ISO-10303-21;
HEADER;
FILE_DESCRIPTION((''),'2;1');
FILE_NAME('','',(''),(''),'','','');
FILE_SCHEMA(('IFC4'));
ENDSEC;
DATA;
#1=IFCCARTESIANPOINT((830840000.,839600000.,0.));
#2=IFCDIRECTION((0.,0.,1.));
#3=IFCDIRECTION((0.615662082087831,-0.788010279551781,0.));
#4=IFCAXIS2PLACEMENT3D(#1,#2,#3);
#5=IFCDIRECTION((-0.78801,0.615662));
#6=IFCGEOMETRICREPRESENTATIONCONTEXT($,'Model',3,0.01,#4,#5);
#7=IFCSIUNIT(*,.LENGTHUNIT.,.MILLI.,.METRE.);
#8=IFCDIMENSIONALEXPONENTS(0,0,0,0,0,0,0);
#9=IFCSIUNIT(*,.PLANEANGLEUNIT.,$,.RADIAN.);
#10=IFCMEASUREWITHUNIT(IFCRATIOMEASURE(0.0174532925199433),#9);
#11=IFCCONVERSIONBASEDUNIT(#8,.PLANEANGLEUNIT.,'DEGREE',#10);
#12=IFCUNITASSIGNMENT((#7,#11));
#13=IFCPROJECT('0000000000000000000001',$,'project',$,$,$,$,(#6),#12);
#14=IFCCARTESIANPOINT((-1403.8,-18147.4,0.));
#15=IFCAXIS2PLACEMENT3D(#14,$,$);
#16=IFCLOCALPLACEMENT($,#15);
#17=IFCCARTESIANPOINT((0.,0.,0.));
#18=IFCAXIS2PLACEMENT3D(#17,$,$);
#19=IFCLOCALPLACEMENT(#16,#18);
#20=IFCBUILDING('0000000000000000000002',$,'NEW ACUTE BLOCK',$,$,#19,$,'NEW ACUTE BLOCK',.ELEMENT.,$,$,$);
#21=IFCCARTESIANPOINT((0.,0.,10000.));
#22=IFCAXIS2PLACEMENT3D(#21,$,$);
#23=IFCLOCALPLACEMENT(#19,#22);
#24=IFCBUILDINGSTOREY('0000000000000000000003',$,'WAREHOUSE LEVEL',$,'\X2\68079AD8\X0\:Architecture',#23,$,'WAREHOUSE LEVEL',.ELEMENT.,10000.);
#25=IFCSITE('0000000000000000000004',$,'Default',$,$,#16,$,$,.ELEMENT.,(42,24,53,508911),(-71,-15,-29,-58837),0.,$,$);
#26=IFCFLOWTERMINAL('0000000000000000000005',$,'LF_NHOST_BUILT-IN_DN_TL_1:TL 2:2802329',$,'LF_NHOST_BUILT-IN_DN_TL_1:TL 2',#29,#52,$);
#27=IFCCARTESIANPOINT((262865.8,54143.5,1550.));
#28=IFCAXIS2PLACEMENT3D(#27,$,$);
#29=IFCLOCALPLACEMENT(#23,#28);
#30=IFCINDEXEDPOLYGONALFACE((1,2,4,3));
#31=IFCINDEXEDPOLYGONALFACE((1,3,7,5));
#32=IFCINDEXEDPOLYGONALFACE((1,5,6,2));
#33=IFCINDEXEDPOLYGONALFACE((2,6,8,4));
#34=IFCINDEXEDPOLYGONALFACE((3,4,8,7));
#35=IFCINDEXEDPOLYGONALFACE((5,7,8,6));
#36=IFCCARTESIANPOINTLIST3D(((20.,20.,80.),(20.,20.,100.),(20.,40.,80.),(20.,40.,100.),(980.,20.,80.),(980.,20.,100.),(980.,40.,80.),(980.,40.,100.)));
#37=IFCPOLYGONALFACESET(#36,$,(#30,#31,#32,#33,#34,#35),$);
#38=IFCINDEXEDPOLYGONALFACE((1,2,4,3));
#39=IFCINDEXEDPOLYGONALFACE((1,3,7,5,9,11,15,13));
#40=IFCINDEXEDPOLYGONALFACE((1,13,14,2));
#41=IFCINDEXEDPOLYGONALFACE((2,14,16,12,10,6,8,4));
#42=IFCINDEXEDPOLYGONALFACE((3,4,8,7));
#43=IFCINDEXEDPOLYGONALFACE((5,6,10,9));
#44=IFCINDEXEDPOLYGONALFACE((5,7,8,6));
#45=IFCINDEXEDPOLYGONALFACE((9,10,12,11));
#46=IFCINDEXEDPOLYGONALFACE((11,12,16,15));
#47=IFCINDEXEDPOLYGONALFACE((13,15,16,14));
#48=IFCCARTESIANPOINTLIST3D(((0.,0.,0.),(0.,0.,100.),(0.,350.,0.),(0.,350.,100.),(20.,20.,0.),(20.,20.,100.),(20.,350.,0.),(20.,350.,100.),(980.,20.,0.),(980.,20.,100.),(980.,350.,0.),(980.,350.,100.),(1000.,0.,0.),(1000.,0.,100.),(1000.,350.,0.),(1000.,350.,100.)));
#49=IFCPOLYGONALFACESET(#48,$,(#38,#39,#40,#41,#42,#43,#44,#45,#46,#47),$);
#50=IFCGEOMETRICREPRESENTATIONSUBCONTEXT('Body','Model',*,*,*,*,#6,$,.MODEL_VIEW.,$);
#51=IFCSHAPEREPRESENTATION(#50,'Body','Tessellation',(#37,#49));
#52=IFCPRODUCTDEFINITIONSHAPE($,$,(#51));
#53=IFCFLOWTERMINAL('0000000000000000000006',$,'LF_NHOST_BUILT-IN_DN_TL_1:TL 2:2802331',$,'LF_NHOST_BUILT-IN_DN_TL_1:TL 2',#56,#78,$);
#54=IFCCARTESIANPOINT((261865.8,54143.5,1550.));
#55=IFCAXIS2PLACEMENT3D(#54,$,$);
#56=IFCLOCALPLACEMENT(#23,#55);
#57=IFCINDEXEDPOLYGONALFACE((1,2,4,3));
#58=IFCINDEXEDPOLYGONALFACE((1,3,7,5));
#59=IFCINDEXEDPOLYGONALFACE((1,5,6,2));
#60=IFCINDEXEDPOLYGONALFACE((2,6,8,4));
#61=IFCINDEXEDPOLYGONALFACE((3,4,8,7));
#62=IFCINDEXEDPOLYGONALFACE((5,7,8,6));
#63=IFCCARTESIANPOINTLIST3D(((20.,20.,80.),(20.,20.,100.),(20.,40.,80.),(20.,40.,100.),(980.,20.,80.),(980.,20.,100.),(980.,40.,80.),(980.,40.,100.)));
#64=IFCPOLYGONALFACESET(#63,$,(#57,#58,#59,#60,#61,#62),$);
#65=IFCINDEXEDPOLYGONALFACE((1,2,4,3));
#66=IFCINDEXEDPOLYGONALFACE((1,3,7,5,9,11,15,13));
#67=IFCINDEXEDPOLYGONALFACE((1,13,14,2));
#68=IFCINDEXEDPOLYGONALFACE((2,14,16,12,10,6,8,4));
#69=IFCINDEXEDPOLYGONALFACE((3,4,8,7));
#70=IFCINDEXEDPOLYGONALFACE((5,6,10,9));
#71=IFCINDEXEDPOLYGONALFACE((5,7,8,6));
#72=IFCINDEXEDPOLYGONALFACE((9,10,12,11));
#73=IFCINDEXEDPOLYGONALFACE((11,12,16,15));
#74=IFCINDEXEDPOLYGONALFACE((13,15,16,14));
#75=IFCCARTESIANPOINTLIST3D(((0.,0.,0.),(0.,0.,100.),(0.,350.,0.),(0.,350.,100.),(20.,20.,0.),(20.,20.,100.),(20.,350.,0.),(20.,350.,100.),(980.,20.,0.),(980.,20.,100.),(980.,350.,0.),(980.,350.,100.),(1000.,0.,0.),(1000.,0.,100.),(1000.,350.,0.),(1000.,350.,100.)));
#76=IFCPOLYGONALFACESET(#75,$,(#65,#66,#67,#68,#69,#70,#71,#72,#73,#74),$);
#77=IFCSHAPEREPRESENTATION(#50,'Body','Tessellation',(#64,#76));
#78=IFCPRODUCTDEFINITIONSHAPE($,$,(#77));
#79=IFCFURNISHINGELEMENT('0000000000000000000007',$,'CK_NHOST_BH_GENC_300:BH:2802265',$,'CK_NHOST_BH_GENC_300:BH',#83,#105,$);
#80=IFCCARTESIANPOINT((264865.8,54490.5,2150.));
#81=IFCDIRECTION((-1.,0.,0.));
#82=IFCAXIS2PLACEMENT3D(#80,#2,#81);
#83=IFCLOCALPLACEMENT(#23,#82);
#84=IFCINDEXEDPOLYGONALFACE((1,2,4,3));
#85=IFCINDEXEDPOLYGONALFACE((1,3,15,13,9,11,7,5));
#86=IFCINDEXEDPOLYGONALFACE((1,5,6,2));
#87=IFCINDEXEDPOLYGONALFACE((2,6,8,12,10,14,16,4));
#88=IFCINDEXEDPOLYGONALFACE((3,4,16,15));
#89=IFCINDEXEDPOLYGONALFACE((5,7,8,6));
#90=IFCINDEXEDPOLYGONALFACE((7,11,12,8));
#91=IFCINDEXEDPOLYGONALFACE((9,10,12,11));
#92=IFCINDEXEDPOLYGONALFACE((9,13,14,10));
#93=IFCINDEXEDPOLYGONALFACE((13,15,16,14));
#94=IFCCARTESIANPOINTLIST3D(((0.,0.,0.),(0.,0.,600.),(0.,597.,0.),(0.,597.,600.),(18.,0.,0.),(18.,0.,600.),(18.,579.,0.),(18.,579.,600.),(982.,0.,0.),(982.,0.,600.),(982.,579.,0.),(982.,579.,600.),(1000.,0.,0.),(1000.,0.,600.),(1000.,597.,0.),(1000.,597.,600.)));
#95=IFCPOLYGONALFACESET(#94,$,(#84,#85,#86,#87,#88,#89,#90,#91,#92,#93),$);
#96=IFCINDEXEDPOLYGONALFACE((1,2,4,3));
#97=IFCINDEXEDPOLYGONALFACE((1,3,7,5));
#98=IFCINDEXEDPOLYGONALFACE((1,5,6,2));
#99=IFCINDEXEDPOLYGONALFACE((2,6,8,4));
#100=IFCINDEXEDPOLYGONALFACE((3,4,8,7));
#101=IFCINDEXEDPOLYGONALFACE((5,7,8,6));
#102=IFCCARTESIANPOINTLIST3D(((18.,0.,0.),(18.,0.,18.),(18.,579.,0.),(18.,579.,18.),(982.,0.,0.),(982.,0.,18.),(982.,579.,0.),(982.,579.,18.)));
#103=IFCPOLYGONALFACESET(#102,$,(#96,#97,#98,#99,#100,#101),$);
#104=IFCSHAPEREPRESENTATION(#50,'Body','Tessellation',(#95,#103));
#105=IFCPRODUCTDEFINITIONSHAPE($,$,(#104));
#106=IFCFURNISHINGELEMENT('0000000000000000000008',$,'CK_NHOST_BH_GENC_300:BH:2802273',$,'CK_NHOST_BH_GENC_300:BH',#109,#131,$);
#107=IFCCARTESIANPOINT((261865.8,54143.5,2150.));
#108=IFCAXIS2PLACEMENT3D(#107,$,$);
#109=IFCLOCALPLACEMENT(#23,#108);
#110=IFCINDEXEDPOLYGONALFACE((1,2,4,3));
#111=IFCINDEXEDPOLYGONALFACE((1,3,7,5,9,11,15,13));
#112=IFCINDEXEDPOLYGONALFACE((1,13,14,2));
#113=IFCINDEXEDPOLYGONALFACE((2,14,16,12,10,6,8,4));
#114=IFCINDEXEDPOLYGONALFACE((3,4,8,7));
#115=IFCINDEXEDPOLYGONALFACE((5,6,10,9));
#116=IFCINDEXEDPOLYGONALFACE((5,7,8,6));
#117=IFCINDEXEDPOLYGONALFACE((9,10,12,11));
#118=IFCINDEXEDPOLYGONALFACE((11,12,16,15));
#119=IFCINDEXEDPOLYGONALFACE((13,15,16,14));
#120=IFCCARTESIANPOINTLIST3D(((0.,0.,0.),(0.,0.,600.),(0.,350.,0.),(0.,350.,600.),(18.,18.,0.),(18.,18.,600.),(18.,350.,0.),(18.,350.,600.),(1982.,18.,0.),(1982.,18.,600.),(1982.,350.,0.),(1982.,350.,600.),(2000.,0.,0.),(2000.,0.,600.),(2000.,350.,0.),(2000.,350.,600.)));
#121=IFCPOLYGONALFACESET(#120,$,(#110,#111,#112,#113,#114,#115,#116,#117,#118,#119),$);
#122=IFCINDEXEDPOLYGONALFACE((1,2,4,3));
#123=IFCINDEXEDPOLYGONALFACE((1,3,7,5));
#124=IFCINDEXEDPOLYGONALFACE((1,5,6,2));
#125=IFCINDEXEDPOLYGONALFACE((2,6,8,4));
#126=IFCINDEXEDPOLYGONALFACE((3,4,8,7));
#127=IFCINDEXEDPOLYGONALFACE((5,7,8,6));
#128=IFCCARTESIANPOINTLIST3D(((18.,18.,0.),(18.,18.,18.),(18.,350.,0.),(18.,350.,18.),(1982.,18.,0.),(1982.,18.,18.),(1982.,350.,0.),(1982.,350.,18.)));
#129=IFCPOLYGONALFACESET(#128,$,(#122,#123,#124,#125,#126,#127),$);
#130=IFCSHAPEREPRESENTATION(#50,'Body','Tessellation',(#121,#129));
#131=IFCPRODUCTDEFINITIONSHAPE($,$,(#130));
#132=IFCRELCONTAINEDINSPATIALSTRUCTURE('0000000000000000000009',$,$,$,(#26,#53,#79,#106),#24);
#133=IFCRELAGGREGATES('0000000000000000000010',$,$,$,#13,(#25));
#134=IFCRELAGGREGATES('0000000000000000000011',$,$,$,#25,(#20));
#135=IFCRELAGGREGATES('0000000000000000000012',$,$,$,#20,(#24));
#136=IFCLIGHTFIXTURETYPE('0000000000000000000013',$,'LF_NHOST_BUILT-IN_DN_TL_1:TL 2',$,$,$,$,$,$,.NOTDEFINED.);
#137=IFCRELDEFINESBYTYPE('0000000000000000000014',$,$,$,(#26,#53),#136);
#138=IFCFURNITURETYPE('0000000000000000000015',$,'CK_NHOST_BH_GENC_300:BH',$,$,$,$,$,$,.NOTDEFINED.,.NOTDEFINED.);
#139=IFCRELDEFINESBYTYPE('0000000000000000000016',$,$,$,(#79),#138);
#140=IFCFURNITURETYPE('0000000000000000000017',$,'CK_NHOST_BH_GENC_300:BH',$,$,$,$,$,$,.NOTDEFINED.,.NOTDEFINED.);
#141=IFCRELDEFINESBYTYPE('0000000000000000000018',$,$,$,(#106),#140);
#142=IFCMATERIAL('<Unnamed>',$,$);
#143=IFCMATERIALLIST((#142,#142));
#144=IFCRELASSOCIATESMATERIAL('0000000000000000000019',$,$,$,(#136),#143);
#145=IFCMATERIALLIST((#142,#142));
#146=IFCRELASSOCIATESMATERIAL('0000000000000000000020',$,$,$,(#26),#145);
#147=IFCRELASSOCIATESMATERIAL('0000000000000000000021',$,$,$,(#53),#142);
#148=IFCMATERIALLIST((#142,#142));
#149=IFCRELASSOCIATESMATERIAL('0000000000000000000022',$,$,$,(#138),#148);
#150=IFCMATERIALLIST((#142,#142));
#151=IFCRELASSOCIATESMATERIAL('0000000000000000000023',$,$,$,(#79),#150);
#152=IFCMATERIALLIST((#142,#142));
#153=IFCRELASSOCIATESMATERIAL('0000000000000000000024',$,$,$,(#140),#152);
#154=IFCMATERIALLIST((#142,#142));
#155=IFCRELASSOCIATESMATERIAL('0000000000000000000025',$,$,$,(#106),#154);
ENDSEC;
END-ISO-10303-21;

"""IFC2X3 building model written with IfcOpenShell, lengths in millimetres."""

from ifc_helpers import new_model, entity, si_unit, converted_unit, direction, frame, origin, origin_2d_with_axis, place, context, subcontext, project, spatial, polyline, rectangle, outline, extrude, source, transform, mapped, material, material_list, type_object, type_shapes, element, save


model = new_model("IFC2X3")

# Units and contexts
model_context = context("Model", 3, precision=0.01, world=frame((830840000.0, 839600000.0, 0.0), z_axis=(0.0, 0.0, 1.0), x_axis=(0.615662082087831, -0.788010279551781, 0.0)), true_north=direction((-0.78801, 0.615662)))
body_context = subcontext(model_context, "Body", "Model", "MODEL_VIEW")
ifc_project = project(units=[si_unit("LENGTHUNIT", "METRE", prefix="MILLI"), converted_unit("PLANEANGLEUNIT", "DEGREE", entity("IfcRatioMeasure", 0.0174532925199433), si_unit("PLANEANGLEUNIT", "RADIAN"), dimensions=[0, 0, 0, 0, 0, 0, 0])], contexts=[model_context])

# Site, building, storey
site_placement = place(None, frame((-1403.8, -18147.4, 0.0)))
site = spatial("IfcSite", under=ifc_project, at=site_placement, Name="Default", CompositionType="ELEMENT", RefLatitude=(42, 24, 53, 508911), RefLongitude=(-71, -15, -29, -58837), RefElevation=0.0)
building_placement = place(site_placement, origin())
building = spatial("IfcBuilding", under=site, at=building_placement, Name="NEW ACUTE BLOCK", LongName="NEW ACUTE BLOCK", CompositionType="ELEMENT")
storey_placement = place(building_placement, frame((0.0, 0.0, 10000.0)))
storey = spatial("IfcBuildingStorey", under=building, at=storey_placement, Name="WAREHOUSE LEVEL", ObjectType="标高:Architecture", LongName="WAREHOUSE LEVEL", CompositionType="ELEMENT", Elevation=10000.0)

# Shared definitions
ifc_material_1 = material(Name="<Unnamed>")

# Flow terminals
ifc_material_list_1 = material_list([ifc_material_1, ifc_material_1])
ifc_material_list_2 = material_list([ifc_material_1, ifc_material_1])
light_fixture_type = type_object("IfcLightFixtureType", Name="LF_NHOST_BUILT-IN_DN_TL_1:TL 2", PredefinedType="NOTDEFINED", material=ifc_material_list_2)
shared_shape_1 = source(origin(), body_context, "Body", "SweptSolid", [
    extrude(rectangle(XDim=960.0, YDim=20.0, at=origin_2d_with_axis()), frame((500.0, 30.0, 80.0), z_axis=(0.0, 0.0, 1.0), x_axis=(-1.0, 0.0, 0.0)), (0.0, 0.0, 1.0), 20.0),
    extrude(outline(polyline([(-180.0, -500.0), (170.0, -500.0), (170.0, -480.0), (-160.0, -480.0), (-160.0, 480.0), (170.0, 480.0), (170.0, 500.0), (-180.0, 500.0), (-180.0, -500.0)])), frame((500.0, 180.0, 0.0), z_axis=(0.0, 0.0, 1.0), x_axis=(0.0, 1.0, 0.0)), (0.0, 0.0, 1.0), 100.0),
])
type_shapes(light_fixture_type, [shared_shape_1])
flow_terminal_1_placement = place(storey_placement, frame((262865.8, 54143.5, 1550.0)))
element("IfcFlowTerminal", 1, at=flow_terminal_1_placement, inside=storey, type_object=light_fixture_type, material=ifc_material_list_1, Name="LF_NHOST_BUILT-IN_DN_TL_1:TL 2:2802329", ObjectType="LF_NHOST_BUILT-IN_DN_TL_1:TL 2", context=body_context, shape_type="MappedRepresentation", body=[
    mapped(shared_shape_1, transform((0.0, 0.0, 0.0), scale=1.0)),
])
flow_terminal_2_placement = place(storey_placement, frame((261865.8, 54143.5, 1550.0)))
element("IfcFlowTerminal", 2, at=flow_terminal_2_placement, inside=storey, type_object=light_fixture_type, material=ifc_material_1, Name="LF_NHOST_BUILT-IN_DN_TL_1:TL 2:2802331", ObjectType="LF_NHOST_BUILT-IN_DN_TL_1:TL 2", context=body_context, shape_type="MappedRepresentation", body=[
    mapped(shared_shape_1, transform((0.0, 0.0, 0.0), scale=1.0)),
])

# Furnishing element
ifc_material_list_3 = material_list([ifc_material_1, ifc_material_1])
ifc_material_list_4 = material_list([ifc_material_1, ifc_material_1])
furniture_type_1 = type_object("IfcFurnitureType", Name="CK_NHOST_BH_GENC_300:BH", material=ifc_material_list_4)
shared_shape_2 = source(origin(), body_context, "Body", "SweptSolid", [
    extrude(outline(polyline([(-500.0, -303.0), (500.0, -303.0), (500.0, 294.0), (482.0, 294.0), (482.0, -285.0), (-482.0, -285.0), (-482.0, 294.0), (-500.0, 294.0), (-500.0, -303.0)])), frame((500.0, 294.0, 0.0), z_axis=(0.0, 0.0, 1.0), x_axis=(-1.0, 0.0, 0.0)), (0.0, 0.0, 1.0), 600.0),
    extrude(rectangle(XDim=579.0, YDim=964.0, at=origin_2d_with_axis()), frame((500.0, 289.5, 0.0), z_axis=(0.0, 0.0, 1.0), x_axis=(0.0, 1.0, 0.0)), (0.0, 0.0, 1.0), 18.0),
])
type_shapes(furniture_type_1, [shared_shape_2])
furnishing_1_placement = place(storey_placement, frame((264865.8, 54490.5, 2150.0), z_axis=(0.0, 0.0, 1.0), x_axis=(-1.0, 0.0, 0.0)))
element("IfcFurnishingElement", 3, at=furnishing_1_placement, inside=storey, type_object=furniture_type_1, material=ifc_material_list_3, Name="CK_NHOST_BH_GENC_300:BH:2802265", ObjectType="CK_NHOST_BH_GENC_300:BH", context=body_context, shape_type="MappedRepresentation", body=[
    mapped(shared_shape_2, transform((0.0, 0.0, 0.0), scale=1.0)),
])

# Furnishing element
ifc_material_list_5 = material_list([ifc_material_1, ifc_material_1])
ifc_material_list_6 = material_list([ifc_material_1, ifc_material_1])
furniture_type_2 = type_object("IfcFurnitureType", Name="CK_NHOST_BH_GENC_300:BH", material=ifc_material_list_6)
shared_shape_3 = source(origin(), body_context, "Body", "SweptSolid", [
    extrude(outline(polyline([(-179.5, -1000.0), (170.5, -1000.0), (170.5, -982.0), (-161.5, -982.0), (-161.5, 982.0), (170.5, 982.0), (170.5, 1000.0), (-179.5, 1000.0), (-179.5, -1000.0)])), frame((1000.0, 179.5, 0.0), z_axis=(0.0, 0.0, 1.0), x_axis=(0.0, 1.0, 0.0)), (0.0, 0.0, 1.0), 600.0),
    extrude(rectangle(XDim=1964.0, YDim=332.0, at=origin_2d_with_axis()), frame((1000.0, 184.0, 0.0), z_axis=(0.0, 0.0, 1.0), x_axis=(-1.0, 0.0, 0.0)), (0.0, 0.0, 1.0), 18.0),
])
type_shapes(furniture_type_2, [shared_shape_3])
furnishing_2_placement = place(storey_placement, frame((261865.8, 54143.5, 2150.0)))
element("IfcFurnishingElement", 4, at=furnishing_2_placement, inside=storey, type_object=furniture_type_2, material=ifc_material_list_5, Name="CK_NHOST_BH_GENC_300:BH:2802273", ObjectType="CK_NHOST_BH_GENC_300:BH", context=body_context, shape_type="MappedRepresentation", body=[
    mapped(shared_shape_3, transform((0.0, 0.0, 0.0), scale=1.0)),
])

save(model, "model.ifc")
